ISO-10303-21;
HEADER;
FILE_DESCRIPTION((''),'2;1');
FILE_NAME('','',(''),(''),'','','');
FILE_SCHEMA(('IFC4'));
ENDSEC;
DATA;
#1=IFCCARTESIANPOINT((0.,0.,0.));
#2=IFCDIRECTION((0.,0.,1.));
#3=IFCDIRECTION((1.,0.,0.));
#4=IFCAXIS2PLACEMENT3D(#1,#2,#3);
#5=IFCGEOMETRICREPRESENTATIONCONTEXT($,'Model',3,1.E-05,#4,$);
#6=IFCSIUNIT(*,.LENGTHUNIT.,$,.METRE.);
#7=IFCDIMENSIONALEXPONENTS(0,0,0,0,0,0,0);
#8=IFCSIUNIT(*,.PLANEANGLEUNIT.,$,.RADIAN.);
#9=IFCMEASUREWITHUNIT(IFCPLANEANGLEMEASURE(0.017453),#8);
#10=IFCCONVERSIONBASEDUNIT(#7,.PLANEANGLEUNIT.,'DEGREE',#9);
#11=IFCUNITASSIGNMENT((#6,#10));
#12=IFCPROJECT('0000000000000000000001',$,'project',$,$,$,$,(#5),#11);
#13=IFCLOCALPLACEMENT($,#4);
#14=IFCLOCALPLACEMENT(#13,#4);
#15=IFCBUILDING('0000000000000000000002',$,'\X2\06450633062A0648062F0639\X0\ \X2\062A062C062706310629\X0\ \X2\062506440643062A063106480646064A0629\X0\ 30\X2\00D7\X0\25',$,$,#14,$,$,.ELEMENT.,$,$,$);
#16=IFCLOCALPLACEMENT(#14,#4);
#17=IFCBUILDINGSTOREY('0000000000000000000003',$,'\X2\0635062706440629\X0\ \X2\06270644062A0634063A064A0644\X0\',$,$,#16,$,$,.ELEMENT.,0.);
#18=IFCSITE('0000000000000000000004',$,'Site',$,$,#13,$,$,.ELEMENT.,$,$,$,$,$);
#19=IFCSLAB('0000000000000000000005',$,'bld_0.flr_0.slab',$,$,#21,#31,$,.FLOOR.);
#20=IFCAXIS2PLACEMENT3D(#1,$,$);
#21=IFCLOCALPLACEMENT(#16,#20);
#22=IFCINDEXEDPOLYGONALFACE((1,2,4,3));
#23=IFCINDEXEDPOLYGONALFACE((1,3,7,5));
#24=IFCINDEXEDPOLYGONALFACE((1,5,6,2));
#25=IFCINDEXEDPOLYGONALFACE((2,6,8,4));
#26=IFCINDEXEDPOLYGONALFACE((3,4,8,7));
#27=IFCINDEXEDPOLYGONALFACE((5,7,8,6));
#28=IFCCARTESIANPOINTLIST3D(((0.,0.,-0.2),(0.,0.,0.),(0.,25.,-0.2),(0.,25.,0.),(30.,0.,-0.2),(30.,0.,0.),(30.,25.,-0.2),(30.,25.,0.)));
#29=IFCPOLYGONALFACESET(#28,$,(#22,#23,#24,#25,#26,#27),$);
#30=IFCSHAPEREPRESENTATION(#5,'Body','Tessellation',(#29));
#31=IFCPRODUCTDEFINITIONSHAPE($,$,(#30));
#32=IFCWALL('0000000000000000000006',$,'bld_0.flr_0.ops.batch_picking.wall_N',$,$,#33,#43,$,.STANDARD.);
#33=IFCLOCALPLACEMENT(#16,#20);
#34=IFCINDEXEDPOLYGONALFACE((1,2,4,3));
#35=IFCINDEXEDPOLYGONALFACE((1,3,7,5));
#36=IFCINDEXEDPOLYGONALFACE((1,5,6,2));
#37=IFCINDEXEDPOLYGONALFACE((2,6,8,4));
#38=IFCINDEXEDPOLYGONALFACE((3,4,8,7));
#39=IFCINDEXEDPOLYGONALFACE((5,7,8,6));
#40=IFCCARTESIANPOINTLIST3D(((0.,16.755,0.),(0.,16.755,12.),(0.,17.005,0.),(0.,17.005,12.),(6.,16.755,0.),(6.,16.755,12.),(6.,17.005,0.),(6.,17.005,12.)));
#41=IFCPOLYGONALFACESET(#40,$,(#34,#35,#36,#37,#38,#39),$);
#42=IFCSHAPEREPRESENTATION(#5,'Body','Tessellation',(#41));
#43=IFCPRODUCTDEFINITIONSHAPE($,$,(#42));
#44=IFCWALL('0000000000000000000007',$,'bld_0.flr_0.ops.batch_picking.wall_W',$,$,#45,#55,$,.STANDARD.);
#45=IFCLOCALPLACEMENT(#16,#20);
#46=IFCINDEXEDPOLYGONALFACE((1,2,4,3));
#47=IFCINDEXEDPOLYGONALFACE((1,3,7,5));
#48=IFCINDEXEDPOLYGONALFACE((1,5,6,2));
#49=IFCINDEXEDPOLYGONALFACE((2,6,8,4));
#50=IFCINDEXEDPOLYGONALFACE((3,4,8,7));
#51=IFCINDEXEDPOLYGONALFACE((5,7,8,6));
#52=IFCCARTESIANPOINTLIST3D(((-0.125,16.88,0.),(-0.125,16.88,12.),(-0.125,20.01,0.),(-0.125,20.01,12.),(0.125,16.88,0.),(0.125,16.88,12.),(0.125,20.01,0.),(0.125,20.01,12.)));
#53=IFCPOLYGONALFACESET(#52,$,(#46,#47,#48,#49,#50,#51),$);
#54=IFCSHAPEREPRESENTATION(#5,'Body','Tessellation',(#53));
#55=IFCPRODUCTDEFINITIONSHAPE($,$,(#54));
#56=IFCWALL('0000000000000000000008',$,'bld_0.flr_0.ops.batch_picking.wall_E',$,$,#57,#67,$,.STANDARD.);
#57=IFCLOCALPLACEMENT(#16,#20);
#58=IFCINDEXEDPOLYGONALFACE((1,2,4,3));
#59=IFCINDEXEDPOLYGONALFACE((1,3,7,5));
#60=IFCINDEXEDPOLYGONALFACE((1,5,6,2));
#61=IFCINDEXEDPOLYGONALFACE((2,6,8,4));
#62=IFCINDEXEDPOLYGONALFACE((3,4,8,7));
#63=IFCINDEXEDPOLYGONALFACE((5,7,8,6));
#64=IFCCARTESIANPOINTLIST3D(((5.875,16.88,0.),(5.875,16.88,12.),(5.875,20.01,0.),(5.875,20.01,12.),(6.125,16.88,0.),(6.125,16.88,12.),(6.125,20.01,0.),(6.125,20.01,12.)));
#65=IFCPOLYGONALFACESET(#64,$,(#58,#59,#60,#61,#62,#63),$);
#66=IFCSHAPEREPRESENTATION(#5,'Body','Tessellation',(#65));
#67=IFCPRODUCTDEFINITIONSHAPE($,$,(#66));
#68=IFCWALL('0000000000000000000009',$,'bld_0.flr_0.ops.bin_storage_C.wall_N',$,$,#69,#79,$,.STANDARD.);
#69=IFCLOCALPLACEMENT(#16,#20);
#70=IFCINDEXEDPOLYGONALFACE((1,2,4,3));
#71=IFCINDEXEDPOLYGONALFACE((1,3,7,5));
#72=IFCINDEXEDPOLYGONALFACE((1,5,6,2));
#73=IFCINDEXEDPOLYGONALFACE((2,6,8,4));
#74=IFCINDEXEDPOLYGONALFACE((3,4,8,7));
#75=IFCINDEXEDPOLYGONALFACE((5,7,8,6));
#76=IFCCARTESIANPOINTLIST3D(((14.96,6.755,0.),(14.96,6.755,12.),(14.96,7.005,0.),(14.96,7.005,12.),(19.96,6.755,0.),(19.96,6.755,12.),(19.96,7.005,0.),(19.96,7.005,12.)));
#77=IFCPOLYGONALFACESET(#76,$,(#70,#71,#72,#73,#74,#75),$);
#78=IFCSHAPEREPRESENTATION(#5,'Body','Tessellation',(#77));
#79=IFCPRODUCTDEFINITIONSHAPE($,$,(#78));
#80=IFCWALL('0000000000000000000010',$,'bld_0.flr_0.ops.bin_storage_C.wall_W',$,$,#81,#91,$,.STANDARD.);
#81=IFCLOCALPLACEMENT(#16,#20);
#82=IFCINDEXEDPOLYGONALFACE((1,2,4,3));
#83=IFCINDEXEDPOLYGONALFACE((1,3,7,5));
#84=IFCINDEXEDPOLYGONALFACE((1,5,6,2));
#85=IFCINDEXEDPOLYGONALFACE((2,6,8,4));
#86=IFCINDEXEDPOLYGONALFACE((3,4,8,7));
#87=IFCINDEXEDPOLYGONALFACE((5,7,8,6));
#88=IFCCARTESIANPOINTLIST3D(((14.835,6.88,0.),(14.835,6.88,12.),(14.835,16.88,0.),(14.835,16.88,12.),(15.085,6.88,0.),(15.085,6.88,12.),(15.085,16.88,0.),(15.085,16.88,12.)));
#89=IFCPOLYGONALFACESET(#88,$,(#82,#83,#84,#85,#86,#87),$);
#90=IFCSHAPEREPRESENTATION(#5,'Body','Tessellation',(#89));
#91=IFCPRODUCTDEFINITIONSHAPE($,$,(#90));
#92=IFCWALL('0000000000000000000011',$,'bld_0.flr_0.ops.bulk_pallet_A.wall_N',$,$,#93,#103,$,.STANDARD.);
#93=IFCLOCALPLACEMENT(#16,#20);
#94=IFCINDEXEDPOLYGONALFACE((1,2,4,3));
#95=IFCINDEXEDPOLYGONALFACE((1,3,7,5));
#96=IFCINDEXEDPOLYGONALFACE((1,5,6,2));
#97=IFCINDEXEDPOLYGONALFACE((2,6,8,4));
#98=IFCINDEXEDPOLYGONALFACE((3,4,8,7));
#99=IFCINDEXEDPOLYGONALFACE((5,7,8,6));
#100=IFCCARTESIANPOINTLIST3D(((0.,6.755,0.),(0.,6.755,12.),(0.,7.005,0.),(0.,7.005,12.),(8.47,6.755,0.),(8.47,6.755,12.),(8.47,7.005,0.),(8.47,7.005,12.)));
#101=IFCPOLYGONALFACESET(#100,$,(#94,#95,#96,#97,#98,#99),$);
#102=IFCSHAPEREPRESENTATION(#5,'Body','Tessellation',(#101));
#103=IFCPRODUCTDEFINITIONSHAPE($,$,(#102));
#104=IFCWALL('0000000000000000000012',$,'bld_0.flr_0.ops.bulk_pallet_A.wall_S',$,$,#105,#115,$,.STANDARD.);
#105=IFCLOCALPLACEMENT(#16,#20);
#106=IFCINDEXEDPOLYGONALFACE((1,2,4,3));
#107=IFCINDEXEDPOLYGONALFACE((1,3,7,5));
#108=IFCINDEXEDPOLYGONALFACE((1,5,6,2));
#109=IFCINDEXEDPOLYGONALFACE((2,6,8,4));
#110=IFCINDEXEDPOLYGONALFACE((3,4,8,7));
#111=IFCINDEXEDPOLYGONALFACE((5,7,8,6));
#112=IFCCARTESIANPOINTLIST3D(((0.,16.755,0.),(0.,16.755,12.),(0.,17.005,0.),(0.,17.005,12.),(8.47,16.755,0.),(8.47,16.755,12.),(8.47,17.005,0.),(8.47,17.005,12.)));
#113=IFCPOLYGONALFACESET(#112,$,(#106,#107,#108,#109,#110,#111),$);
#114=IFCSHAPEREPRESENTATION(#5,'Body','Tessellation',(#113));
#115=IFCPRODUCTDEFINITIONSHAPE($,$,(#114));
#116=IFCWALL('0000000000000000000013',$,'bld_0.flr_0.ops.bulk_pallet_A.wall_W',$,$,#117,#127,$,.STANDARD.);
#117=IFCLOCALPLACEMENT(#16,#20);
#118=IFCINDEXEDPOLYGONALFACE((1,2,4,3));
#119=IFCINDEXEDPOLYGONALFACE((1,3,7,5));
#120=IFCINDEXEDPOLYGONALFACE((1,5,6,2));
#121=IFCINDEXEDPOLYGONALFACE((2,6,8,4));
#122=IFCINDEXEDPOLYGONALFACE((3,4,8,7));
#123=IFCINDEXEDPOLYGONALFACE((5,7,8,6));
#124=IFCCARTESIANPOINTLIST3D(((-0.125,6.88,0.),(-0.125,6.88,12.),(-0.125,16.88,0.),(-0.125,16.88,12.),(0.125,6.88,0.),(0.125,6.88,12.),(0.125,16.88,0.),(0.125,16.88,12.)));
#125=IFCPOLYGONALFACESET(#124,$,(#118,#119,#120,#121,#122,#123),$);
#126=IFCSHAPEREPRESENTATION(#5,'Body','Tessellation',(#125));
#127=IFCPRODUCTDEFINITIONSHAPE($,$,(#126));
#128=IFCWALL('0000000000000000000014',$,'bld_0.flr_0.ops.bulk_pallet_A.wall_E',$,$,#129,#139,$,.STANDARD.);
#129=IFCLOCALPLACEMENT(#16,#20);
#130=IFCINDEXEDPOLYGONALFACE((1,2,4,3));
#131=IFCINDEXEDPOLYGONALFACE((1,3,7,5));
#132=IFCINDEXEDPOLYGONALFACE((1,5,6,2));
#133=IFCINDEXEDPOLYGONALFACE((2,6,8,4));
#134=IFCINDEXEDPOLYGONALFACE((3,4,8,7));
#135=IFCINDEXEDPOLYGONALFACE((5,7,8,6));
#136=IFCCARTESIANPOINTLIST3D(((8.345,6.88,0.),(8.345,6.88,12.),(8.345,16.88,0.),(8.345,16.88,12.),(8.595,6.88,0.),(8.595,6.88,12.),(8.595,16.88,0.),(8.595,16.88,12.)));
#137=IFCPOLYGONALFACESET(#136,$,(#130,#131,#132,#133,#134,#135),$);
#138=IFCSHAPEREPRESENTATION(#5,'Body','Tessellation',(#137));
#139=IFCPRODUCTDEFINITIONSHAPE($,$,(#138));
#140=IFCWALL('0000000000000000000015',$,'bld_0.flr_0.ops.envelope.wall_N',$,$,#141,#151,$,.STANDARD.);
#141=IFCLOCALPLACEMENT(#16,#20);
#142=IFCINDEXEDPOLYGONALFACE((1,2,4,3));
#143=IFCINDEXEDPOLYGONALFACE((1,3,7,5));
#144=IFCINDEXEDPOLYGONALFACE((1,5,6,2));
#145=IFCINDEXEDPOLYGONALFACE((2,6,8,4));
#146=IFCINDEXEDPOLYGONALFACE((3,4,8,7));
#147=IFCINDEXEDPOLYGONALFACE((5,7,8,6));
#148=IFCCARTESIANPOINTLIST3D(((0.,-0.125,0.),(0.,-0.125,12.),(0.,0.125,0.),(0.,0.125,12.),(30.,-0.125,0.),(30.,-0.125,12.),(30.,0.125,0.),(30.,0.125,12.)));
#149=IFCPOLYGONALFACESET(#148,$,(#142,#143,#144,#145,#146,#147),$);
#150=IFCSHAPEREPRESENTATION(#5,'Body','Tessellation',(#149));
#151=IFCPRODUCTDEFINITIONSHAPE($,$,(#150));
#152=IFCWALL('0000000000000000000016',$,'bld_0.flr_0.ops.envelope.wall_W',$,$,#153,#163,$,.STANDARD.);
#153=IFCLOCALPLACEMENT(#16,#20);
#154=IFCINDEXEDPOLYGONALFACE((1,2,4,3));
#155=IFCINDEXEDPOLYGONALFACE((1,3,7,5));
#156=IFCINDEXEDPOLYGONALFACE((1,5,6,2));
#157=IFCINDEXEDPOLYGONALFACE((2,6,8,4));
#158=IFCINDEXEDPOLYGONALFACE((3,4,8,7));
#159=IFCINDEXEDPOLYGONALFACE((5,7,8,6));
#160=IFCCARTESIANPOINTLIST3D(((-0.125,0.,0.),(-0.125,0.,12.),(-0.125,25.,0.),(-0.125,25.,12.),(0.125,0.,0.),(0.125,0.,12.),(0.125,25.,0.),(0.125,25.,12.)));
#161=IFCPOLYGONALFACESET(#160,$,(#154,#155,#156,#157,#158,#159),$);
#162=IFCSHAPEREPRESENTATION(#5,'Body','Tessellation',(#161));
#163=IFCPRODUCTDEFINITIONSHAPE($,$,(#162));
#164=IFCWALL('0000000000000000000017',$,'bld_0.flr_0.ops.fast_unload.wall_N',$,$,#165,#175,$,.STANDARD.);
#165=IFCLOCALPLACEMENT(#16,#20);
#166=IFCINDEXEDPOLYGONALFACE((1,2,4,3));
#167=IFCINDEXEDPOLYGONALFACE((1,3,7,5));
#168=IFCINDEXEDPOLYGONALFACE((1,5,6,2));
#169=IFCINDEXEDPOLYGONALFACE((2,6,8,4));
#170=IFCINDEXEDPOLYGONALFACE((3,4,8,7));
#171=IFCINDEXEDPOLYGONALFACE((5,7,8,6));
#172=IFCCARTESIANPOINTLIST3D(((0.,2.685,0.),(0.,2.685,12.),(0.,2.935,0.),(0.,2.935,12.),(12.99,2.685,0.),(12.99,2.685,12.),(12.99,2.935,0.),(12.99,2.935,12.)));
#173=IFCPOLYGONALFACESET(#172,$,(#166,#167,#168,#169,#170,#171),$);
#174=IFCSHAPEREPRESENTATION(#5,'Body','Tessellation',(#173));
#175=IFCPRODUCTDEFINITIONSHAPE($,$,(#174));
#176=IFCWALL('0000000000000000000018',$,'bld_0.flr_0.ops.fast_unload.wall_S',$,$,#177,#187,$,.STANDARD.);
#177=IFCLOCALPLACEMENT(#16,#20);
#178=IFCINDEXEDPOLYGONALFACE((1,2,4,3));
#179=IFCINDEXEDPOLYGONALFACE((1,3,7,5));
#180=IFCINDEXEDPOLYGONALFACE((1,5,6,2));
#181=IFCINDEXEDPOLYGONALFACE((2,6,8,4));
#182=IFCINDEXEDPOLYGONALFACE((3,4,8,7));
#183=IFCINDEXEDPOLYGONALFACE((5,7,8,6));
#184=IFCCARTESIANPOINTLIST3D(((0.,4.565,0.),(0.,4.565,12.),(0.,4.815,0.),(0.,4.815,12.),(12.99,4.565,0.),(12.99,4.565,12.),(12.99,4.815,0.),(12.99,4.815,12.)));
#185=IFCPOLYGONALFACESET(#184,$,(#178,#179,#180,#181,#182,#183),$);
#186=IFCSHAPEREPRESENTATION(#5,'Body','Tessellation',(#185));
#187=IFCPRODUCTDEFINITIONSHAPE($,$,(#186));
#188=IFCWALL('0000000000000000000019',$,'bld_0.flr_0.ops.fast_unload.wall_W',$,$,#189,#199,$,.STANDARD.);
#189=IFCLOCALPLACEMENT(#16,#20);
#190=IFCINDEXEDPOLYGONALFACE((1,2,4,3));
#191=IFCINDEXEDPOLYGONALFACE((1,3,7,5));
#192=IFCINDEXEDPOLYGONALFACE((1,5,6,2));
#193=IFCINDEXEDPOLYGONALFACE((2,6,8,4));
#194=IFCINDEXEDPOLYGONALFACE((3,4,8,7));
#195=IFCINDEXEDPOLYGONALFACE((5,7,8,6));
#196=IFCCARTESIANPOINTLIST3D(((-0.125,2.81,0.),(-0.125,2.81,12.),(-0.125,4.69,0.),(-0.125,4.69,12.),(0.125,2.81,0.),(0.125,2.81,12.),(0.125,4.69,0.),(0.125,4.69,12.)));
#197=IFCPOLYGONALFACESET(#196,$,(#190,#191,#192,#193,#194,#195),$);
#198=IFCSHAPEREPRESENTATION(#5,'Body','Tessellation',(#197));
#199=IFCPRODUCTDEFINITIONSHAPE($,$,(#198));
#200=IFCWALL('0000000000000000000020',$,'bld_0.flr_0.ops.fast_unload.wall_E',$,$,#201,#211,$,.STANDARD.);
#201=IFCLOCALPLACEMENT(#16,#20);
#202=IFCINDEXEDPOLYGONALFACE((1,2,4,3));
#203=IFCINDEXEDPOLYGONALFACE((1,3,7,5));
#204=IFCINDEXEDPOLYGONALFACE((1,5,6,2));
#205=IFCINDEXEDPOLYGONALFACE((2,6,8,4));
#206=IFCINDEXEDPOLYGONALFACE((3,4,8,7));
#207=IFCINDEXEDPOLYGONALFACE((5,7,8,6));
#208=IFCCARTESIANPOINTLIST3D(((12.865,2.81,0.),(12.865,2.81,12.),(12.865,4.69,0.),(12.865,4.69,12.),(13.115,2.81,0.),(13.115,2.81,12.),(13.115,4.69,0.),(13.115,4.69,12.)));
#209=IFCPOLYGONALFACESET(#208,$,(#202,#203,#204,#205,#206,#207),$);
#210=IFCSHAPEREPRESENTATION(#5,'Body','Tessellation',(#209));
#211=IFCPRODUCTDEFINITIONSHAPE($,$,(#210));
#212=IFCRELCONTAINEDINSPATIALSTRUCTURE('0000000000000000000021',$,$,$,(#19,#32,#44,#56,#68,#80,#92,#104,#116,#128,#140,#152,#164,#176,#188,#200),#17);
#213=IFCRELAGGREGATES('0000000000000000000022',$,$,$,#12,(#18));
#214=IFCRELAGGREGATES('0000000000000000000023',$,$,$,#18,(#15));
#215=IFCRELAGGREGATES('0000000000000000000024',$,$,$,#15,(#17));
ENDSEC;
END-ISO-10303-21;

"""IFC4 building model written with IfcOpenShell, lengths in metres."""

from ifc_helpers import new_model, entity, si_unit, converted_unit, frame, frame_2d, origin_with_axes, place, context, project, spatial, rectangle, extrude, element, save


model = new_model("IFC4")

# Units and contexts
model_context = context("Model", 3, precision=1e-05, world=origin_with_axes())
ifc_project = project(units=[si_unit("LENGTHUNIT", "METRE"), converted_unit("PLANEANGLEUNIT", "DEGREE", entity("IfcPlaneAngleMeasure", 0.017453), si_unit("PLANEANGLEUNIT", "RADIAN"), dimensions=[0, 0, 0, 0, 0, 0, 0])], contexts=[model_context])

# Site, building, storey
site_placement = place(None, origin_with_axes())
site = spatial("IfcSite", under=ifc_project, at=site_placement, Name="Site", CompositionType="ELEMENT")
building_placement = place(site_placement, origin_with_axes())
building = spatial("IfcBuilding", under=site, at=building_placement, Name="مستودع تجارة إلكترونية 30×25", CompositionType="ELEMENT")
storey_placement = place(building_placement, origin_with_axes())
storey = spatial("IfcBuildingStorey", under=building, at=storey_placement, Name="صالة التشغيل", CompositionType="ELEMENT", Elevation=0.0)

# Slab
slab_placement = place(storey_placement, origin_with_axes())
element("IfcSlab", 1, at=slab_placement, inside=storey, Name="bld_0.flr_0.slab", PredefinedType="FLOOR", context=model_context, shape_type="SweptSolid", body=[
    extrude(rectangle(XDim=30.0, YDim=25.0, at=frame_2d((15.0, 12.5), x_axis=(1.0, 0.0))), frame((0.0, 0.0, -0.2), z_axis=(0.0, 0.0, 1.0), x_axis=(1.0, 0.0, 0.0)), (0.0, 0.0, 1.0), 0.2),
])

# Walls
wall_1_placement = place(storey_placement, frame((0.0, 16.88, 0.0), z_axis=(0.0, 0.0, 1.0), x_axis=(1.0, 0.0, 0.0)))
element("IfcWall", 2, at=wall_1_placement, inside=storey, Name="bld_0.flr_0.ops.batch_picking.wall_N", PredefinedType="STANDARD", context=model_context, shape_type="SweptSolid", body=[
    extrude(rectangle(XDim=6.0, YDim=0.25, at=frame_2d((3.0, 0.0), x_axis=(1.0, 0.0))), origin_with_axes(), (0.0, 0.0, 1.0), 12.0),
])
for number, where, z_axis, x_axis, name in (
    (3, (0.0, 16.88, 0.0), (0.0, 0.0, 1.0), (0.0, 1.0, 0.0), "bld_0.flr_0.ops.batch_picking.wall_W"),
    (4, (6.0, 16.88, 0.0), (0.0, 0.0, 1.0), (0.0, 1.0, 0.0), "bld_0.flr_0.ops.batch_picking.wall_E"),
):
    element("IfcWall", number, at=place(storey_placement, frame(where, z_axis=z_axis, x_axis=x_axis)), inside=storey, Name=name, PredefinedType="STANDARD", context=model_context, shape_type="SweptSolid", body=[
        extrude(rectangle(XDim=3.13, YDim=0.25, at=frame_2d((1.565, 0.0), x_axis=(1.0, 0.0))), origin_with_axes(), (0.0, 0.0, 1.0), 12.0),
    ])
wall_2_placement = place(storey_placement, frame((14.96, 6.88, 0.0), z_axis=(0.0, 0.0, 1.0), x_axis=(1.0, 0.0, 0.0)))
element("IfcWall", 5, at=wall_2_placement, inside=storey, Name="bld_0.flr_0.ops.bin_storage_C.wall_N", PredefinedType="STANDARD", context=model_context, shape_type="SweptSolid", body=[
    extrude(rectangle(XDim=5.0, YDim=0.25, at=frame_2d((2.5, 0.0), x_axis=(1.0, 0.0))), origin_with_axes(), (0.0, 0.0, 1.0), 12.0),
])
wall_3_placement = place(storey_placement, frame((14.96, 6.88, 0.0), z_axis=(0.0, 0.0, 1.0), x_axis=(0.0, 1.0, 0.0)))
element("IfcWall", 6, at=wall_3_placement, inside=storey, Name="bld_0.flr_0.ops.bin_storage_C.wall_W", PredefinedType="STANDARD", context=model_context, shape_type="SweptSolid", body=[
    extrude(rectangle(XDim=10.0, YDim=0.25, at=frame_2d((5.0, 0.0), x_axis=(1.0, 0.0))), origin_with_axes(), (0.0, 0.0, 1.0), 12.0),
])
for number, where, z_axis, x_axis, name in (
    (7, (0.0, 6.88, 0.0), (0.0, 0.0, 1.0), (1.0, 0.0, 0.0), "bld_0.flr_0.ops.bulk_pallet_A.wall_N"),
    (8, (0.0, 16.88, 0.0), (0.0, 0.0, 1.0), (1.0, 0.0, 0.0), "bld_0.flr_0.ops.bulk_pallet_A.wall_S"),
):
    element("IfcWall", number, at=place(storey_placement, frame(where, z_axis=z_axis, x_axis=x_axis)), inside=storey, Name=name, PredefinedType="STANDARD", context=model_context, shape_type="SweptSolid", body=[
        extrude(rectangle(XDim=8.47, YDim=0.25, at=frame_2d((4.235, 0.0), x_axis=(1.0, 0.0))), origin_with_axes(), (0.0, 0.0, 1.0), 12.0),
    ])
for number, where, z_axis, x_axis, name in (
    (9, (0.0, 6.88, 0.0), (0.0, 0.0, 1.0), (0.0, 1.0, 0.0), "bld_0.flr_0.ops.bulk_pallet_A.wall_W"),
    (10, (8.47, 6.88, 0.0), (0.0, 0.0, 1.0), (0.0, 1.0, 0.0), "bld_0.flr_0.ops.bulk_pallet_A.wall_E"),
):
    element("IfcWall", number, at=place(storey_placement, frame(where, z_axis=z_axis, x_axis=x_axis)), inside=storey, Name=name, PredefinedType="STANDARD", context=model_context, shape_type="SweptSolid", body=[
        extrude(rectangle(XDim=10.0, YDim=0.25, at=frame_2d((5.0, 0.0), x_axis=(1.0, 0.0))), origin_with_axes(), (0.0, 0.0, 1.0), 12.0),
    ])
wall_4_placement = place(storey_placement, origin_with_axes())
element("IfcWall", 11, at=wall_4_placement, inside=storey, Name="bld_0.flr_0.ops.envelope.wall_N", PredefinedType="STANDARD", context=model_context, shape_type="SweptSolid", body=[
    extrude(rectangle(XDim=30.0, YDim=0.25, at=frame_2d((15.0, 0.0), x_axis=(1.0, 0.0))), origin_with_axes(), (0.0, 0.0, 1.0), 12.0),
])
wall_5_placement = place(storey_placement, frame((0.0, 0.0, 0.0), z_axis=(0.0, 0.0, 1.0), x_axis=(0.0, 1.0, 0.0)))
element("IfcWall", 12, at=wall_5_placement, inside=storey, Name="bld_0.flr_0.ops.envelope.wall_W", PredefinedType="STANDARD", context=model_context, shape_type="SweptSolid", body=[
    extrude(rectangle(XDim=25.0, YDim=0.25, at=frame_2d((12.5, 0.0), x_axis=(1.0, 0.0))), origin_with_axes(), (0.0, 0.0, 1.0), 12.0),
])
for number, where, z_axis, x_axis, name in (
    (13, (0.0, 2.81, 0.0), (0.0, 0.0, 1.0), (1.0, 0.0, 0.0), "bld_0.flr_0.ops.fast_unload.wall_N"),
    (14, (0.0, 4.69, 0.0), (0.0, 0.0, 1.0), (1.0, 0.0, 0.0), "bld_0.flr_0.ops.fast_unload.wall_S"),
):
    element("IfcWall", number, at=place(storey_placement, frame(where, z_axis=z_axis, x_axis=x_axis)), inside=storey, Name=name, PredefinedType="STANDARD", context=model_context, shape_type="SweptSolid", body=[
        extrude(rectangle(XDim=12.99, YDim=0.25, at=frame_2d((6.495, 0.0), x_axis=(1.0, 0.0))), origin_with_axes(), (0.0, 0.0, 1.0), 12.0),
    ])
for number, where, z_axis, x_axis, name in (
    (15, (0.0, 2.81, 0.0), (0.0, 0.0, 1.0), (0.0, 1.0, 0.0), "bld_0.flr_0.ops.fast_unload.wall_W"),
    (16, (12.99, 2.81, 0.0), (0.0, 0.0, 1.0), (0.0, 1.0, 0.0), "bld_0.flr_0.ops.fast_unload.wall_E"),
):
    element("IfcWall", number, at=place(storey_placement, frame(where, z_axis=z_axis, x_axis=x_axis)), inside=storey, Name=name, PredefinedType="STANDARD", context=model_context, shape_type="SweptSolid", body=[
        extrude(rectangle(XDim=1.88, YDim=0.25, at=frame_2d((0.94, 0.0), x_axis=(1.0, 0.0))), origin_with_axes(), (0.0, 0.0, 1.0), 12.0),
    ])

save(model, "model.ifc")
